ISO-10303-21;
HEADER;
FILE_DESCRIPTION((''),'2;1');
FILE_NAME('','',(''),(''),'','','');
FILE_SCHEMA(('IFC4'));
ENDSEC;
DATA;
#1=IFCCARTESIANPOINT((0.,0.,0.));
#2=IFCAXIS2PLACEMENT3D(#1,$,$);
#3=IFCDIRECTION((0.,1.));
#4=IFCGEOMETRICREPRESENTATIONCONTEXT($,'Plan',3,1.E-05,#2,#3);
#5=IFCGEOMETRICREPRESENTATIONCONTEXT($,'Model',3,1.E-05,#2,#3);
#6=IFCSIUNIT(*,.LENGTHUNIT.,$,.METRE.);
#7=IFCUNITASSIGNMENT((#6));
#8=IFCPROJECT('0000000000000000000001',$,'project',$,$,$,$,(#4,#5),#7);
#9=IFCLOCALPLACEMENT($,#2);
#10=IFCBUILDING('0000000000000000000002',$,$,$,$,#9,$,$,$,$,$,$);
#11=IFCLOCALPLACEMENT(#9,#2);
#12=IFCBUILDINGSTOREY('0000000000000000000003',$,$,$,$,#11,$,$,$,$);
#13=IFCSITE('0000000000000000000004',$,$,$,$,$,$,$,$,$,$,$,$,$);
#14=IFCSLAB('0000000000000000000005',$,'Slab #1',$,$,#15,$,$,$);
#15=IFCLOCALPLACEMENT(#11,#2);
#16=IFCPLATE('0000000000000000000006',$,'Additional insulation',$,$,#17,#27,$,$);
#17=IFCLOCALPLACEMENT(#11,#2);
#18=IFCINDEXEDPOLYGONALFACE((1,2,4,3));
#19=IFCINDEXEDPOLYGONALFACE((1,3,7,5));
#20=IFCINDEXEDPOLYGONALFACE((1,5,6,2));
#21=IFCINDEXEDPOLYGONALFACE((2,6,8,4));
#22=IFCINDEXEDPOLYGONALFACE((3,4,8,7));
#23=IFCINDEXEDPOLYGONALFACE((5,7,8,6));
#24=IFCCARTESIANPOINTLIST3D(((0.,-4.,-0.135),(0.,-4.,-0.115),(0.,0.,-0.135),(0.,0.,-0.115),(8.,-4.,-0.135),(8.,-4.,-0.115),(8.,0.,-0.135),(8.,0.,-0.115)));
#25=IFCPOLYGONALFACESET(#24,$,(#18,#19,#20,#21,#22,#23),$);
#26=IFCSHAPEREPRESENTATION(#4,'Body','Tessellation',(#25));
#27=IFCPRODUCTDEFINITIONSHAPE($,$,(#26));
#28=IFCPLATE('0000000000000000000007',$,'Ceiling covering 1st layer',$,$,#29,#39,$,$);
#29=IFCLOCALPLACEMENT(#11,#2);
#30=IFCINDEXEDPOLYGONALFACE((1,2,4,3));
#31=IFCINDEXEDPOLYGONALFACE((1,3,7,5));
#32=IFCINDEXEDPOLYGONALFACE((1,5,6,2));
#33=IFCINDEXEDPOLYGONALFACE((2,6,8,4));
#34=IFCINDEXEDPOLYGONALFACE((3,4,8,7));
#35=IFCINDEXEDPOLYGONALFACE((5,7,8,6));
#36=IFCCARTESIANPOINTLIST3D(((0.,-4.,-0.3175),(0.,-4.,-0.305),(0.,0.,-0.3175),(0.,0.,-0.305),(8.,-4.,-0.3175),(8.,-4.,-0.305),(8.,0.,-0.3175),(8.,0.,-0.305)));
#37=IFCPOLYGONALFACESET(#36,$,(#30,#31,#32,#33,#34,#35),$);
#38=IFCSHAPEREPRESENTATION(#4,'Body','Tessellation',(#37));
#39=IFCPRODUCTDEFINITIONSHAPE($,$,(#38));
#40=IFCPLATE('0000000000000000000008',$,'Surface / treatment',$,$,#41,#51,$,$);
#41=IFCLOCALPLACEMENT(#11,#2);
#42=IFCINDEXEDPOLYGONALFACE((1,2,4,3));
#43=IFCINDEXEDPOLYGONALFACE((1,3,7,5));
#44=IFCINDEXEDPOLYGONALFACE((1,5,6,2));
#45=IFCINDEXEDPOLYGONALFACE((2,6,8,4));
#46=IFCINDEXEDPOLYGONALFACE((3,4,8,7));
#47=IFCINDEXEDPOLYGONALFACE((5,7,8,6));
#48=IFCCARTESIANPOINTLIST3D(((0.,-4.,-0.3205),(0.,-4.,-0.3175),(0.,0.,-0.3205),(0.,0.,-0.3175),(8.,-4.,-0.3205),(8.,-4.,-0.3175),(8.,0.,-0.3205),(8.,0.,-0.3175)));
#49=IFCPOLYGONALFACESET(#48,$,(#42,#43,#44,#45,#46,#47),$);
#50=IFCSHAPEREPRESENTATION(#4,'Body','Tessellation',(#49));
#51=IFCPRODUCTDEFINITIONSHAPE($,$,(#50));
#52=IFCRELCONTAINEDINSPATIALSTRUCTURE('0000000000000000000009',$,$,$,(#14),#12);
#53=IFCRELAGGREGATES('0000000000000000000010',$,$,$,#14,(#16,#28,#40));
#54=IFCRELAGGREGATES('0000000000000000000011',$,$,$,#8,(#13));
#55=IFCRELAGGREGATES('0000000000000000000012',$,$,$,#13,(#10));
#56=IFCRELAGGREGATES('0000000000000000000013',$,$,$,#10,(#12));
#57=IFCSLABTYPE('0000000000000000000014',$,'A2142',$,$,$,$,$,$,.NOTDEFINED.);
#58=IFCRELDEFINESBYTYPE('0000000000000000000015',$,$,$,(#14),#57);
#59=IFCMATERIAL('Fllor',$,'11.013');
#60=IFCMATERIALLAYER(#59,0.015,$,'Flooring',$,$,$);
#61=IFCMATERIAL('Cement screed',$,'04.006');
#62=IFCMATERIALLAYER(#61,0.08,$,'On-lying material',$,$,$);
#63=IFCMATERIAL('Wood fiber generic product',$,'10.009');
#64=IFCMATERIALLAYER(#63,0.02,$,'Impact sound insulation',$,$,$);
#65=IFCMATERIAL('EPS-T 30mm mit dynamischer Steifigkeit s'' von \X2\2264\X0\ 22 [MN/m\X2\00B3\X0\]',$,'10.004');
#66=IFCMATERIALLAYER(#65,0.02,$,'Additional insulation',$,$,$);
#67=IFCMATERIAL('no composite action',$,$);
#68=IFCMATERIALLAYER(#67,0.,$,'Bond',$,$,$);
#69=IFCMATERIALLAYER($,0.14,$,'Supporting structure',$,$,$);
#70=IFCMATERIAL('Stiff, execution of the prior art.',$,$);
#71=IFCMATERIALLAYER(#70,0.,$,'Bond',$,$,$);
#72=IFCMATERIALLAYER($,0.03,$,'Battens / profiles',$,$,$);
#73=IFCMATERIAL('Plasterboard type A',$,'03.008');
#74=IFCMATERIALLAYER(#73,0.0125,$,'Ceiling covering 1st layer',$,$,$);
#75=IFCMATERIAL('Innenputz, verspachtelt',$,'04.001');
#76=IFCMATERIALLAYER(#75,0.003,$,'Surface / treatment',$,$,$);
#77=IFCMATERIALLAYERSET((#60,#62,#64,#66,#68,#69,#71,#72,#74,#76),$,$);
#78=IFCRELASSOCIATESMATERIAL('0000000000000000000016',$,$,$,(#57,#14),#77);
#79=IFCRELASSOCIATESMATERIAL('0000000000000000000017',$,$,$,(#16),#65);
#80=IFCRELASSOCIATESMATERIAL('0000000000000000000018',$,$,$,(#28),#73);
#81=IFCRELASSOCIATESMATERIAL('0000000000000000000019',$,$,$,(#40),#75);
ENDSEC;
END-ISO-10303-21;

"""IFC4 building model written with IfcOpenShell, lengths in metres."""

from ifc_helpers import new_model, si_unit, direction, frame, frame_2d, origin, place, context, project, spatial, rectangle, extrude, material, layer, layer_set, type_object, element, aggregate, save


model = new_model("IFC4")

# Units and contexts
plan_context = context("Plan", 3, precision=1e-05, world=origin(), true_north=direction((0.0, 1.0)))
model_context = context("Model", 3, precision=1e-05, world=origin(), true_north=direction((0.0, 1.0)))
ifc_project = project(units=[si_unit("LENGTHUNIT", "METRE")], contexts=[plan_context, model_context])

# Site, building, storey
site = spatial("IfcSite", under=ifc_project)
building_placement = place(None, origin())
building = spatial("IfcBuilding", under=site, at=building_placement)
storey_placement = place(building_placement, origin())
storey = spatial("IfcBuildingStorey", under=building, at=storey_placement)

# Slab, plates
ifc_material_1 = material(Name="Fllor", Category="11.013")
ifc_layer_1 = layer(ifc_material_1, 0.015, Name="Flooring")
ifc_material_2 = material(Name="Cement screed", Category="04.006")
ifc_layer_2 = layer(ifc_material_2, 0.08, Name="On-lying material")
ifc_material_3 = material(Name="Wood fiber generic product", Category="10.009")
ifc_layer_3 = layer(ifc_material_3, 0.02, Name="Impact sound insulation")
ifc_material_4 = material(Name="EPS-T 30mm mit dynamischer Steifigkeit s' von ≤ 22 [MN/m³]", Category="10.004")
ifc_layer_4 = layer(ifc_material_4, 0.02, Name="Additional insulation")
ifc_material_5 = material(Name="no composite action")
ifc_layer_5 = layer(ifc_material_5, 0.0, Name="Bond")
ifc_layer_6 = layer(None, 0.14, Name="Supporting structure")
ifc_material_6 = material(Name="Stiff, execution of the prior art.")
ifc_layer_7 = layer(ifc_material_6, 0.0, Name="Bond")
ifc_layer_8 = layer(None, 0.03, Name="Battens / profiles")
ifc_material_7 = material(Name="Plasterboard type A", Category="03.008")
ifc_layer_9 = layer(ifc_material_7, 0.0125, Name="Ceiling covering 1st layer")
ifc_material_8 = material(Name="Innenputz, verspachtelt", Category="04.001")
ifc_layer_10 = layer(ifc_material_8, 0.003, Name="Surface / treatment")
ifc_layer_set = layer_set([ifc_layer_1, ifc_layer_2, ifc_layer_3, ifc_layer_4, ifc_layer_5, ifc_layer_6, ifc_layer_7, ifc_layer_8, ifc_layer_9, ifc_layer_10])
slab_type = type_object("IfcSlabType", Name="A2142", PredefinedType="NOTDEFINED", material=ifc_layer_set)
slab_placement = place(None, frame((0.0, 0.0, 0.0), z_axis=(0.0, 0.0, -1.0), x_axis=(1.0, 0.0, 0.0)))
slab = element("IfcSlab", 1, at=slab_placement, inside=storey, type_object=slab_type, material=ifc_layer_set, Name="Slab #1")
plate_1_placement = place(slab_placement, origin())
plate_1 = element("IfcPlate", 2, at=plate_1_placement, material=ifc_material_4, Name="Additional insulation", context=plan_context, shape_type="SweptSolid", body=[
    extrude(rectangle(XDim=8.0, YDim=4.0, at=frame_2d((4.0, 2.0), x_axis=(1.0, 0.0))), frame((0.0, 0.0, 0.115), z_axis=(0.0, 0.0, 1.0), x_axis=(1.0, 0.0, 0.0)), (0.0, 0.0, 1.0), 0.02),
])
plate_2_placement = place(slab_placement, origin())
plate_2 = element("IfcPlate", 3, at=plate_2_placement, material=ifc_material_7, Name="Ceiling covering 1st layer", context=plan_context, shape_type="SweptSolid", body=[
    extrude(rectangle(XDim=8.0, YDim=4.0, at=frame_2d((4.0, 2.0), x_axis=(1.0, 0.0))), frame((0.0, 0.0, 0.305), z_axis=(0.0, 0.0, 1.0), x_axis=(1.0, 0.0, 0.0)), (0.0, 0.0, 1.0), 0.0125),
])
plate_3_placement = place(slab_placement, origin())
plate_3 = element("IfcPlate", 4, at=plate_3_placement, material=ifc_material_8, Name="Surface / treatment", context=plan_context, shape_type="SweptSolid", body=[
    extrude(rectangle(XDim=8.0, YDim=4.0, at=frame_2d((4.0, 2.0), x_axis=(1.0, 0.0))), frame((0.0, 0.0, 0.3175), z_axis=(0.0, 0.0, 1.0), x_axis=(1.0, 0.0, 0.0)), (0.0, 0.0, 1.0), 0.003),
])
aggregate(slab, [plate_1, plate_2, plate_3])

save(model, "model.ifc")
